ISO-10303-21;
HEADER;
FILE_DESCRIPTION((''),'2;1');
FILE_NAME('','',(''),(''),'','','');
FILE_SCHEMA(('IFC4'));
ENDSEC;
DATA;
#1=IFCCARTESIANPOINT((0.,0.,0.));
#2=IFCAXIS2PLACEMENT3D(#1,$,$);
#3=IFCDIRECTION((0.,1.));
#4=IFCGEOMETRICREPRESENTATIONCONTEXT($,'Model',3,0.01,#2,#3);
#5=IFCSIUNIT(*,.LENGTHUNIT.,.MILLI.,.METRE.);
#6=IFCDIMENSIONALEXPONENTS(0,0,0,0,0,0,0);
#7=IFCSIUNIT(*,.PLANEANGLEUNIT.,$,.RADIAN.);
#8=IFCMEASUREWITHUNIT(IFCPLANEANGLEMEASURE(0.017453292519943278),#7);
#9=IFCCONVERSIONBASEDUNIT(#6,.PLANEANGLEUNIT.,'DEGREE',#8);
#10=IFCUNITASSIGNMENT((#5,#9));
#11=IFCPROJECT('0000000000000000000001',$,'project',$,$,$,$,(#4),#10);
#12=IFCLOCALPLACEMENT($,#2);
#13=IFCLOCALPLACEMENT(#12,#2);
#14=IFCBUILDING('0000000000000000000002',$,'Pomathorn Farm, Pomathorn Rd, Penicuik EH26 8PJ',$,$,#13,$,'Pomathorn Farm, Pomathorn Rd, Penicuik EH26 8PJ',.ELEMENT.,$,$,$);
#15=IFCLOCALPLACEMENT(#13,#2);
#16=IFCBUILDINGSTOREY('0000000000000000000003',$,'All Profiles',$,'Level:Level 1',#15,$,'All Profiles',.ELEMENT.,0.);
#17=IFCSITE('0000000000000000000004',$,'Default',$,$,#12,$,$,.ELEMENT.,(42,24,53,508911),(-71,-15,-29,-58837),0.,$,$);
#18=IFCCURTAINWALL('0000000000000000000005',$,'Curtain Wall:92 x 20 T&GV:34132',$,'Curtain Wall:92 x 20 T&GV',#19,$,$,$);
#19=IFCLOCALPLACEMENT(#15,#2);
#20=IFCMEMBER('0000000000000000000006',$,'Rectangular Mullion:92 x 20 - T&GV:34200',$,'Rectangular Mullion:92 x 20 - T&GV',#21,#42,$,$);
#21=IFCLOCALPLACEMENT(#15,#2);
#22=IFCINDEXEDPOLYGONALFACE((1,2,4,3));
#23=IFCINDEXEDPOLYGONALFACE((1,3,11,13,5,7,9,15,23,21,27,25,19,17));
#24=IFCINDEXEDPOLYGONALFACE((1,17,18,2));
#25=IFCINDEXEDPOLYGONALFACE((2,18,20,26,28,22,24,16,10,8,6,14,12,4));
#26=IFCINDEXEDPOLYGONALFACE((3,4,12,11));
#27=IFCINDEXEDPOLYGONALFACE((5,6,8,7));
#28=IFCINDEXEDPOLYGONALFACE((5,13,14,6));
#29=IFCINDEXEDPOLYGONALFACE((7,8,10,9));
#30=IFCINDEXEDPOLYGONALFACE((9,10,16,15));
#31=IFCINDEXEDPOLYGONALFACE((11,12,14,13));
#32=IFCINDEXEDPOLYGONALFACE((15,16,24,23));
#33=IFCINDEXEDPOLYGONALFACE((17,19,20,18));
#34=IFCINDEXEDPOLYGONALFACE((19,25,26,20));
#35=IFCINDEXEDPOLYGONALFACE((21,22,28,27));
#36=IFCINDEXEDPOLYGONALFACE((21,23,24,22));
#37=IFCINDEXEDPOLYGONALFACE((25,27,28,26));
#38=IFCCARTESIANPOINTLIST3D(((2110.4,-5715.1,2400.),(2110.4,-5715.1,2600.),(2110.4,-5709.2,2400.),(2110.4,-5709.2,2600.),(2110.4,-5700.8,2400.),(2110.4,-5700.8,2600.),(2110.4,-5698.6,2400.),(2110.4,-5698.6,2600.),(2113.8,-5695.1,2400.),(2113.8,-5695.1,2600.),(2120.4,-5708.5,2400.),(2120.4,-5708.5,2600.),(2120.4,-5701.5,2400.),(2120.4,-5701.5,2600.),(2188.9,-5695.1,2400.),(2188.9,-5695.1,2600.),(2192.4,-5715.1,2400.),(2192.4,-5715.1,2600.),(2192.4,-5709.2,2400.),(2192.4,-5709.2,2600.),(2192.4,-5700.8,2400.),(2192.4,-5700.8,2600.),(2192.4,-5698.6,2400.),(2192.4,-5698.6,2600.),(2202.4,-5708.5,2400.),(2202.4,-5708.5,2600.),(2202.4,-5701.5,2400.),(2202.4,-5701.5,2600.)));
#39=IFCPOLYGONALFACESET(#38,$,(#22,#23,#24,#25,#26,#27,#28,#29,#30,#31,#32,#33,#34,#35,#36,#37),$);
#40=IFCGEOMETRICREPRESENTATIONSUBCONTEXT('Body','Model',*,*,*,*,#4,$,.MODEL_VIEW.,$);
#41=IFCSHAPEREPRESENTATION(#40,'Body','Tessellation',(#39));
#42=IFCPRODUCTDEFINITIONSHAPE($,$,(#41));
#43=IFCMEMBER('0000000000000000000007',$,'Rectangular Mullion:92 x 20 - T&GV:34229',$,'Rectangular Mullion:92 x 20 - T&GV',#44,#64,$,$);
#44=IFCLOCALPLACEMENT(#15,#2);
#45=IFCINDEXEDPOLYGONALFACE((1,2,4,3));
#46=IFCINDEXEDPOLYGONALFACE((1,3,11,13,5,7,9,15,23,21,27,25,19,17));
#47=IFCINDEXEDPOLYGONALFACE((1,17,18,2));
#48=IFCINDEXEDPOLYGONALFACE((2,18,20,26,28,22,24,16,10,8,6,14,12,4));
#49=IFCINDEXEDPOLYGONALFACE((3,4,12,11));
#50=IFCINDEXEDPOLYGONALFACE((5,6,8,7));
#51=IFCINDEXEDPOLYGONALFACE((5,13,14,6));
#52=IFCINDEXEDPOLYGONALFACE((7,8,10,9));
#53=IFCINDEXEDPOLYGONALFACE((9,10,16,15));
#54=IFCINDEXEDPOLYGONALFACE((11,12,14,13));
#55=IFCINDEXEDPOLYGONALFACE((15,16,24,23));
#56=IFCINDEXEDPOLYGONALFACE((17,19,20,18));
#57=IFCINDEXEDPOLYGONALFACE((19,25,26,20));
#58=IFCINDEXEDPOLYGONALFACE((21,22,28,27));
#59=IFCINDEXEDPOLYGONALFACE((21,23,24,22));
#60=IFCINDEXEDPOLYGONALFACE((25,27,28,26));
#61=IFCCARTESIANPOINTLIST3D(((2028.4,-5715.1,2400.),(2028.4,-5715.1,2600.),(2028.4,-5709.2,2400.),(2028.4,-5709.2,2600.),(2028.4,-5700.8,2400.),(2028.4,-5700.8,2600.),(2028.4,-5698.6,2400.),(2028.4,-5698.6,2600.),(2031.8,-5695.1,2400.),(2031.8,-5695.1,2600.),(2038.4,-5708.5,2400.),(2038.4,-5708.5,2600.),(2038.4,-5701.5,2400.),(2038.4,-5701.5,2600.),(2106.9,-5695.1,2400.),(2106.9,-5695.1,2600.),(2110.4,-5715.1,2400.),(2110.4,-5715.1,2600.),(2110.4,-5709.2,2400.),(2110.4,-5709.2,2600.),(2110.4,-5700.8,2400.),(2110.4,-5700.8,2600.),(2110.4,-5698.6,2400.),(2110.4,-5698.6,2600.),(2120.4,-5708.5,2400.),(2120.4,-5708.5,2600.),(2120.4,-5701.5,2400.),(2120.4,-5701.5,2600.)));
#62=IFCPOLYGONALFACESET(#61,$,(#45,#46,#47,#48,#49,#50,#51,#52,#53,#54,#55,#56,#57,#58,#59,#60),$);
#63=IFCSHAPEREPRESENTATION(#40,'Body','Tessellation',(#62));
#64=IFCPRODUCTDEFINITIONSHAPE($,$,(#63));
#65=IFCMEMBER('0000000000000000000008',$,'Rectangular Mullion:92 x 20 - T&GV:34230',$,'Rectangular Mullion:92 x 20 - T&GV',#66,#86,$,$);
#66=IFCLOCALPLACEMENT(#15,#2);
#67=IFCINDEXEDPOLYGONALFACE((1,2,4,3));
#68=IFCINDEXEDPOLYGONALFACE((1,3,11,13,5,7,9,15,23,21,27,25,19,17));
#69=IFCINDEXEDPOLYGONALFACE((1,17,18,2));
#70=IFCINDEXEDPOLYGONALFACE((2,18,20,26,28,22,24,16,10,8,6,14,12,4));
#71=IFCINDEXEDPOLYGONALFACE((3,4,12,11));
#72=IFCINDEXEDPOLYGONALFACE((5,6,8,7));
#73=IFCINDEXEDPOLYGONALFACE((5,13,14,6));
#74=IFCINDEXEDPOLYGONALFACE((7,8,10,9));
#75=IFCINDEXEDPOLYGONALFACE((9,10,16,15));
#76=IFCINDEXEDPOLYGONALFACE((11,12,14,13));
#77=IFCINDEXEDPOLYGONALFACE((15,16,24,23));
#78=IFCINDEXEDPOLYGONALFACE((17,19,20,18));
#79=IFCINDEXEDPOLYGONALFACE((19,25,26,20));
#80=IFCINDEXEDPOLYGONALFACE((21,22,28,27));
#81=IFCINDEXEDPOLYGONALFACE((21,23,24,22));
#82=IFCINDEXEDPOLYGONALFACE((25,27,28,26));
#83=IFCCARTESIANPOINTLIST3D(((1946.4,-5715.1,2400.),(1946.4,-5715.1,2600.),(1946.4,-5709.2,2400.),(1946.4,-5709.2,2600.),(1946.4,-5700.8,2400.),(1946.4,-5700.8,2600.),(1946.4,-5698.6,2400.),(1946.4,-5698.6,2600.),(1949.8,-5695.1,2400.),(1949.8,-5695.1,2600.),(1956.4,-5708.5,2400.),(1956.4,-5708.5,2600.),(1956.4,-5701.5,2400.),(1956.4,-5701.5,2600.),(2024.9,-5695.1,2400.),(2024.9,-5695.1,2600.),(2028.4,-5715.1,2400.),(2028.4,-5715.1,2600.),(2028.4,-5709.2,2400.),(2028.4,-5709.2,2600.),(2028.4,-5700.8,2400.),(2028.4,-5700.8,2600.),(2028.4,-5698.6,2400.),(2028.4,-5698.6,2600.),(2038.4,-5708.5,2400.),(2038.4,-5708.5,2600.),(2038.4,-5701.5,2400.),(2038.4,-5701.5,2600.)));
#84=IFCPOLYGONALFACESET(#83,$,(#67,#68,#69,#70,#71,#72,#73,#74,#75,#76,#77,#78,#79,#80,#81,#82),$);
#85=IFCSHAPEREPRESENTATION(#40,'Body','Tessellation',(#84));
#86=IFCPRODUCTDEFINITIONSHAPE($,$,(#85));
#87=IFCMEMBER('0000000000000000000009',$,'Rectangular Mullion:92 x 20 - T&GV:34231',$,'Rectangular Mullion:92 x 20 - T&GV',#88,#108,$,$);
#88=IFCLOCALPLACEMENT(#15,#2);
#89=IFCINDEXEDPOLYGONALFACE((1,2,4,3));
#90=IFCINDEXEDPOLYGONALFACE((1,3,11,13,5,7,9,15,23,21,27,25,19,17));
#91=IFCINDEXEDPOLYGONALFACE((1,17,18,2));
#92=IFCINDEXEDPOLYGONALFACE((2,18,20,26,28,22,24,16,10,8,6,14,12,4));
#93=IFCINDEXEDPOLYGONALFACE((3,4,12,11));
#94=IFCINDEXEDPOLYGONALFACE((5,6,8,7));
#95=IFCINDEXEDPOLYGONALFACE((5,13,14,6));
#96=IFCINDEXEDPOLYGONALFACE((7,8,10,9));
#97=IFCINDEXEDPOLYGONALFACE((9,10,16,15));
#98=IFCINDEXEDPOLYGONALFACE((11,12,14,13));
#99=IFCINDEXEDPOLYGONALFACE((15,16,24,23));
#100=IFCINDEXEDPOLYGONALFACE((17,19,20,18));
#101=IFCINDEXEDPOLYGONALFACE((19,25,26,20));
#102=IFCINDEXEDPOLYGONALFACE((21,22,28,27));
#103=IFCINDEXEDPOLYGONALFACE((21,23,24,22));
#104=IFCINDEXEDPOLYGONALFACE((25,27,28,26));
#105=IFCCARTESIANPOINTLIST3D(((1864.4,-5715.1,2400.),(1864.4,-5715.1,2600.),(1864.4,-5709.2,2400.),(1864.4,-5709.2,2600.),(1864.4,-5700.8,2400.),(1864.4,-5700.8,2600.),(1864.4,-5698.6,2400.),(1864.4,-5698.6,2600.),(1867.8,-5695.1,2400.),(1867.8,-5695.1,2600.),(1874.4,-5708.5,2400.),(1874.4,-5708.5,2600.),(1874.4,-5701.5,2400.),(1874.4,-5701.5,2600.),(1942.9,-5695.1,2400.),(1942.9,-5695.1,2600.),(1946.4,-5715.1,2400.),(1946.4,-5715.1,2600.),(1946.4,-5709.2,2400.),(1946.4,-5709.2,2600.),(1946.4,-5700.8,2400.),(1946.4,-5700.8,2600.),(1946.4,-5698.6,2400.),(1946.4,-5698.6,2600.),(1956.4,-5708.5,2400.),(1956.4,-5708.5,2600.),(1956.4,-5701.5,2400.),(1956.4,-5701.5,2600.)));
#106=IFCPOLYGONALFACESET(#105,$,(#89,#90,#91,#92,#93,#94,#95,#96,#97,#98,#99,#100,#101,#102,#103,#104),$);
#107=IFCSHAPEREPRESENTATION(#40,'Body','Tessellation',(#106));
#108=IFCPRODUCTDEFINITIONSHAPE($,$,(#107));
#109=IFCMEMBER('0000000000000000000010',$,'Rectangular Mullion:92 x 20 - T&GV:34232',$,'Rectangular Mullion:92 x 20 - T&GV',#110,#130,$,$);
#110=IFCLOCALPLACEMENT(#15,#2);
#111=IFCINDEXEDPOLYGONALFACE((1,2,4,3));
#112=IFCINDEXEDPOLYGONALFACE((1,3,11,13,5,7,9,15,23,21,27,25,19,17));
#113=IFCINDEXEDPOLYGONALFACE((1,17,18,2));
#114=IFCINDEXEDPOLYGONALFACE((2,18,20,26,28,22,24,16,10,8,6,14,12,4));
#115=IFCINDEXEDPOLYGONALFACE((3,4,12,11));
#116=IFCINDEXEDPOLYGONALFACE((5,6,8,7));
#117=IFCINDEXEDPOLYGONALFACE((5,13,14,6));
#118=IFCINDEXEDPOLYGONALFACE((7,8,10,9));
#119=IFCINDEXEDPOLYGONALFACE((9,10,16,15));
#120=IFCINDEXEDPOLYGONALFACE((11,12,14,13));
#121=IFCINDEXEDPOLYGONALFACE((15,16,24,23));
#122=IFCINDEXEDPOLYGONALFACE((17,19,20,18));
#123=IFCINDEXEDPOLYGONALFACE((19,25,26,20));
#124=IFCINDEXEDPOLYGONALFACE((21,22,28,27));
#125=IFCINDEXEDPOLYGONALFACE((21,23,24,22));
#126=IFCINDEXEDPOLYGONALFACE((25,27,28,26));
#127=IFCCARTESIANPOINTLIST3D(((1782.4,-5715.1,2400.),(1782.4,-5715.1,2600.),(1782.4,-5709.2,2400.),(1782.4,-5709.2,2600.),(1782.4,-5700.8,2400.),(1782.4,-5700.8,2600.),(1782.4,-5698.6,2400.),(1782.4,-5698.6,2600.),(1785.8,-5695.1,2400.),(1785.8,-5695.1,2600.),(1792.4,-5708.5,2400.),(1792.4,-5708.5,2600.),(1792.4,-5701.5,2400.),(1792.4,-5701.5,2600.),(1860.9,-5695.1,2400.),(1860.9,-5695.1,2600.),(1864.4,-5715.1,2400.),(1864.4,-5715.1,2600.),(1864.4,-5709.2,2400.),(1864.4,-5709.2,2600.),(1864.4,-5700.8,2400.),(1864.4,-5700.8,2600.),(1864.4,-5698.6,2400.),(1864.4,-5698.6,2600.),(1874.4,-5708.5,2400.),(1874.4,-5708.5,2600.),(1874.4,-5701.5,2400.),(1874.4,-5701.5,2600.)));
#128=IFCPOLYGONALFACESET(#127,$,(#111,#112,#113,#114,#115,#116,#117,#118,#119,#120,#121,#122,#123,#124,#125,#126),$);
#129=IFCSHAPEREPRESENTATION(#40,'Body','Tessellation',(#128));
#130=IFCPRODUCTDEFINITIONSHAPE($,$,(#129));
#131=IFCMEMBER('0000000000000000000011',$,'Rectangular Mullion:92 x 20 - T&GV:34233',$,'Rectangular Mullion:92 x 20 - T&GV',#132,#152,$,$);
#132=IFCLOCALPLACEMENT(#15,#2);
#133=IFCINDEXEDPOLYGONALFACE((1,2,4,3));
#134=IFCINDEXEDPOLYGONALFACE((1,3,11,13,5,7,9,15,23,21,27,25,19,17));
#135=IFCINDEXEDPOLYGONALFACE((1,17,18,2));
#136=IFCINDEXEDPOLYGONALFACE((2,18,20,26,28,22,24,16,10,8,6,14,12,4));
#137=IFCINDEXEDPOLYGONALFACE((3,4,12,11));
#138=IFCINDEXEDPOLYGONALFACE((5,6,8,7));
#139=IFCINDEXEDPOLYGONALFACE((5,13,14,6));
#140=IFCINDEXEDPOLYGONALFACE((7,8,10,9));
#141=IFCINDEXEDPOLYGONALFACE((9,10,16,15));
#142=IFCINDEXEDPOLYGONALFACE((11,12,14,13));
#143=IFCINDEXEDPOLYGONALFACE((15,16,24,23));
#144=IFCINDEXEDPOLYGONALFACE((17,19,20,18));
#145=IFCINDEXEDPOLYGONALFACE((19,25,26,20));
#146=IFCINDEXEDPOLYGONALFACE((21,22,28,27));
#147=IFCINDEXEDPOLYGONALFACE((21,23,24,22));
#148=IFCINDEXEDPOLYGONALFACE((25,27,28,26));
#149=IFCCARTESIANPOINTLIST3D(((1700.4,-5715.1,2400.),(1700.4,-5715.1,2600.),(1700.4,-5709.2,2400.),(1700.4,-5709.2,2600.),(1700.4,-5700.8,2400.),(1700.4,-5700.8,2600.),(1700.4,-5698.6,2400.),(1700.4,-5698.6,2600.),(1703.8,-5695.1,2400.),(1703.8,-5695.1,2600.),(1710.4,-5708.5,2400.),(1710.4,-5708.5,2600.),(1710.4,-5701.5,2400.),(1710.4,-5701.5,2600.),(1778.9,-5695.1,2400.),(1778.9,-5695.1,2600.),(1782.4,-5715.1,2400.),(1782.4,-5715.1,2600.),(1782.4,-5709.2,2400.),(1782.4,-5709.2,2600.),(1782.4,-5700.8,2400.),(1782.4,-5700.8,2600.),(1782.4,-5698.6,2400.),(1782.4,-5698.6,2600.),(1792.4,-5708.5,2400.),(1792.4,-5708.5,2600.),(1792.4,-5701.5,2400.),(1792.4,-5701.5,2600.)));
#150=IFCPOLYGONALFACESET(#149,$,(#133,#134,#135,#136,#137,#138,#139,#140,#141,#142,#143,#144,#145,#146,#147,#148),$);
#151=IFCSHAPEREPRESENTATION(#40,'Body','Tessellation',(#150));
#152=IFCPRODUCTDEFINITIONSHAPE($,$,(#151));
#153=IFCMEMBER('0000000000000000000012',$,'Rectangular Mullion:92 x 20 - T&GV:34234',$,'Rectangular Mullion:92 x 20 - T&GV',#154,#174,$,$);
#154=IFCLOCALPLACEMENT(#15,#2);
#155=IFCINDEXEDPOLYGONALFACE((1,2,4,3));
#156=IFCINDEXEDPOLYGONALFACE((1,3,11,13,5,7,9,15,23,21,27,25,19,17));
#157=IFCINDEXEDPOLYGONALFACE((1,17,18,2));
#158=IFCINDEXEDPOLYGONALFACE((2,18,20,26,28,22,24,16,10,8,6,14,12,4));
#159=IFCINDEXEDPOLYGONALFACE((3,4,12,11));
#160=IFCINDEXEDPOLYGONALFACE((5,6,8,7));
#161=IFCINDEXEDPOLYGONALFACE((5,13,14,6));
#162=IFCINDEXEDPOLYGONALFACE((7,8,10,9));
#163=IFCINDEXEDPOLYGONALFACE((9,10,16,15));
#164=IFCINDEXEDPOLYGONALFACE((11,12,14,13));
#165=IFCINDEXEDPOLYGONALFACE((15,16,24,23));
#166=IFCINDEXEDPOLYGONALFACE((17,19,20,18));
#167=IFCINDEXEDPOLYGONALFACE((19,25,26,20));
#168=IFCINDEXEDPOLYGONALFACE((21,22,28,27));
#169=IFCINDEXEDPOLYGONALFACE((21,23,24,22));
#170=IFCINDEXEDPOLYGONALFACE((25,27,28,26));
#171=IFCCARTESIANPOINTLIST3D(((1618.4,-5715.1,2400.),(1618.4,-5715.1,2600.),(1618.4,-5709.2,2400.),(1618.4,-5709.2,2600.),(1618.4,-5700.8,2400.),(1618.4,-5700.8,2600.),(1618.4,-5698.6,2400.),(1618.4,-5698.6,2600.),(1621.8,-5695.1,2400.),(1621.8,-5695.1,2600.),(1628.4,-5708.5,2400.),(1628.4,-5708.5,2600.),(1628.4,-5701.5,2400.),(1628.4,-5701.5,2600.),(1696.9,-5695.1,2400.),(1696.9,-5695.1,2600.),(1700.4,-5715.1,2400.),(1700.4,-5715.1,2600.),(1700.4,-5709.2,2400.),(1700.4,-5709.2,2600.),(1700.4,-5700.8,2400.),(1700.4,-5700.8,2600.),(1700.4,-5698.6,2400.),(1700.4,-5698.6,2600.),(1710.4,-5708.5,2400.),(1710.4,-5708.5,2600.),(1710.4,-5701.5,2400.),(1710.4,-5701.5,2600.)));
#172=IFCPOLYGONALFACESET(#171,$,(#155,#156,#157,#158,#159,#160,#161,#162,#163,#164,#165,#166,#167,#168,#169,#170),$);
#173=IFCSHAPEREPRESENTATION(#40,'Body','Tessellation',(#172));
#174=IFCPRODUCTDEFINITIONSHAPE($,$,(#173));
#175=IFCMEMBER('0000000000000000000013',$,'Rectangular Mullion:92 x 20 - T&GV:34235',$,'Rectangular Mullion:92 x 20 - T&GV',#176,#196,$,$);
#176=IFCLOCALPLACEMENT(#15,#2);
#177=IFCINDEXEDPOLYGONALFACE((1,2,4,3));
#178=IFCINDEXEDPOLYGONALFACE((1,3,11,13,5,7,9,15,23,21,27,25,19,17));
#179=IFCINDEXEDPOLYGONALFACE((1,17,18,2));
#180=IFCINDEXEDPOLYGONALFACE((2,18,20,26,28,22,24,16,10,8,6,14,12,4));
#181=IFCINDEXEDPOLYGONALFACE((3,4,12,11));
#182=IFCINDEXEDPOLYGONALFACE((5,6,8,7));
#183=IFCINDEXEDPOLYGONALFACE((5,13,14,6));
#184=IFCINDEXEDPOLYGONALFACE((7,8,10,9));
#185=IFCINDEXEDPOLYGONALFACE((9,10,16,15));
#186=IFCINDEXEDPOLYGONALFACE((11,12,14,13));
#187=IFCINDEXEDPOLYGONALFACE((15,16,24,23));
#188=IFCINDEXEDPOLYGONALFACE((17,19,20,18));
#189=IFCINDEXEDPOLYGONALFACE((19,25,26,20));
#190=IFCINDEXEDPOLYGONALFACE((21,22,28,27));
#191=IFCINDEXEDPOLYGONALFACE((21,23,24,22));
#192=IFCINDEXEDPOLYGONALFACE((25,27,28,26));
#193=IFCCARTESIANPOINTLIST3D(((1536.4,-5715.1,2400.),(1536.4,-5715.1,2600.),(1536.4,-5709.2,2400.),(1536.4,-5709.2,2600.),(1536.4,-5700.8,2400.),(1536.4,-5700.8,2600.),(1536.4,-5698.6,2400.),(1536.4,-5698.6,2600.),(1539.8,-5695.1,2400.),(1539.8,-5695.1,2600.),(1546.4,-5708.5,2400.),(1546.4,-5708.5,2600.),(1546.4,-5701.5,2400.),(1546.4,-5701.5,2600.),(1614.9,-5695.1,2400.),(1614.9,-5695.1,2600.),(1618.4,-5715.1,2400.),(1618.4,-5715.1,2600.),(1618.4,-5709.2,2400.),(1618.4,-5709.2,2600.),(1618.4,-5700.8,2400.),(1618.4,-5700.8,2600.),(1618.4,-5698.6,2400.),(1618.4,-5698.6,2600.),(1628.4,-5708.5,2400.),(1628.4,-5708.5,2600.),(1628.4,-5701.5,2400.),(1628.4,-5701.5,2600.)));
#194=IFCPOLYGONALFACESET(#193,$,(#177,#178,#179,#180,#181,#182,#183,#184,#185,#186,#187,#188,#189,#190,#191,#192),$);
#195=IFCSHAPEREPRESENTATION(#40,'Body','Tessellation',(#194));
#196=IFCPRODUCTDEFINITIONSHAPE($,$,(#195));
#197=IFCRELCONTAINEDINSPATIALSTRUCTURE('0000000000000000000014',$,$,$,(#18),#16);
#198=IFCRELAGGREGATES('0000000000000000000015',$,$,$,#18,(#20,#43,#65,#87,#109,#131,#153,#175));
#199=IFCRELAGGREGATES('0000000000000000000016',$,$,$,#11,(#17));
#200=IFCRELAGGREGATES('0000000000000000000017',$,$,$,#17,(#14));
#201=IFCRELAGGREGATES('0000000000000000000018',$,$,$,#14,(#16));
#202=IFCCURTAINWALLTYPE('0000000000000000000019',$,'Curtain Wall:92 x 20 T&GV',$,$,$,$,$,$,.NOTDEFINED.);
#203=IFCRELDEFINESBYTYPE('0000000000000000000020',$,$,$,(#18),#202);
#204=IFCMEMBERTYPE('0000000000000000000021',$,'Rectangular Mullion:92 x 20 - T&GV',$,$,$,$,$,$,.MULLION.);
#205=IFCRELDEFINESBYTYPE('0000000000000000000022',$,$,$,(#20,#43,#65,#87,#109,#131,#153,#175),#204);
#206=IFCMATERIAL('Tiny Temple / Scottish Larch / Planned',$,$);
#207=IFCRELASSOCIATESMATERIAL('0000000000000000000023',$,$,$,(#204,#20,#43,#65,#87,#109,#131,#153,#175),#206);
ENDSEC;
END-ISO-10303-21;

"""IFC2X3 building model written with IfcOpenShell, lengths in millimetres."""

from ifc_helpers import new_model, entity, si_unit, converted_unit, direction, frame, origin, place, context, subcontext, project, spatial, polyline, outline, extrude, source, transform, mapped, material, type_object, type_shapes, element, aggregate, save


model = new_model("IFC2X3")

# Units and contexts
model_context = context("Model", 3, precision=0.01, world=origin(), true_north=direction((0.0, 1.0)))
body_context = subcontext(model_context, "Body", "Model", "MODEL_VIEW")
ifc_project = project(units=[si_unit("LENGTHUNIT", "METRE", prefix="MILLI"), converted_unit("PLANEANGLEUNIT", "DEGREE", entity("IfcPlaneAngleMeasure", 0.017453292519943278), si_unit("PLANEANGLEUNIT", "RADIAN"), dimensions=[0, 0, 0, 0, 0, 0, 0])], contexts=[model_context])

# Site, building, storey
site_placement = place(None, origin())
site = spatial("IfcSite", under=ifc_project, at=site_placement, Name="Default", CompositionType="ELEMENT", RefLatitude=(42, 24, 53, 508911), RefLongitude=(-71, -15, -29, -58837), RefElevation=0.0)
building_placement = place(site_placement, origin())
building = spatial("IfcBuilding", under=site, at=building_placement, Name="Pomathorn Farm, Pomathorn Rd, Penicuik EH26 8PJ", LongName="Pomathorn Farm, Pomathorn Rd, Penicuik EH26 8PJ", CompositionType="ELEMENT")
storey_placement = place(building_placement, origin())
storey = spatial("IfcBuildingStorey", under=building, at=storey_placement, Name="All Profiles", ObjectType="Level:Level 1", LongName="All Profiles", CompositionType="ELEMENT", Elevation=0.0)

# Shared definitions
ifc_material = material(Name="Tiny Temple / Scottish Larch / Planned")

# Curtain wall, members
curtain_wall_type_1 = type_object("IfcCurtainWallType", Name="Curtain Wall:92 x 20 T&GV", PredefinedType="NOTDEFINED")
curtain_wall_1_placement = place(storey_placement, origin())
curtain_wall_1 = element("IfcCurtainWall", 1, at=curtain_wall_1_placement, inside=storey, type_object=curtain_wall_type_1, Name="Curtain Wall:92 x 20 T&GV:34132", ObjectType="Curtain Wall:92 x 20 T&GV")
member_type_1 = type_object("IfcMemberType", Name="Rectangular Mullion:92 x 20 - T&GV", PredefinedType="MULLION", material=ifc_material)
shared_shape_1 = source(origin(), body_context, "Body", "SweptSolid", [
    extrude(outline(polyline([(-38.1, -11.0), (43.9, -11.0), (43.9, -5.1), (33.9, -4.4), (33.9, 2.6), (43.9, 3.3), (43.9, 5.5), (40.4, 9.0), (-34.7, 9.0), (-38.1, 5.5), (-38.1, 3.3), (-48.1, 2.6), (-48.1, -4.4), (-38.1, -5.1), (-38.1, -11.0)])), frame((-48.1, -11.0, -200.0), z_axis=(0.0, 0.0, 1.0), x_axis=(-1.0, 0.0, 0.0)), (0.0, 0.0, 1.0), 200.0),
])
type_shapes(member_type_1, [shared_shape_1])
member_1_placement = place(curtain_wall_1_placement, frame((2202.4, -5715.1, 2400.0), z_axis=(0.0, 0.0, -1.0), x_axis=(1.0, 0.0, 0.0)))
member_1 = element("IfcMember", 2, at=member_1_placement, type_object=member_type_1, material=ifc_material, Name="Rectangular Mullion:92 x 20 - T&GV:34200", ObjectType="Rectangular Mullion:92 x 20 - T&GV", context=body_context, shape_type="MappedRepresentation", body=[
    mapped(shared_shape_1, transform((0.0, 0.0, 0.0), scale=1.0)),
])
member_2_placement = place(curtain_wall_1_placement, frame((2120.4, -5715.1, 2400.0), z_axis=(0.0, 0.0, -1.0), x_axis=(1.0, 0.0, 0.0)))
member_2 = element("IfcMember", 3, at=member_2_placement, type_object=member_type_1, material=ifc_material, Name="Rectangular Mullion:92 x 20 - T&GV:34229", ObjectType="Rectangular Mullion:92 x 20 - T&GV", context=body_context, shape_type="MappedRepresentation", body=[
    mapped(shared_shape_1, transform((0.0, 0.0, 0.0), scale=1.0)),
])
member_3_placement = place(curtain_wall_1_placement, frame((2038.4, -5715.1, 2400.0), z_axis=(0.0, 0.0, -1.0), x_axis=(1.0, 0.0, 0.0)))
member_3 = element("IfcMember", 4, at=member_3_placement, type_object=member_type_1, material=ifc_material, Name="Rectangular Mullion:92 x 20 - T&GV:34230", ObjectType="Rectangular Mullion:92 x 20 - T&GV", context=body_context, shape_type="MappedRepresentation", body=[
    mapped(shared_shape_1, transform((0.0, 0.0, 0.0), scale=1.0)),
])
member_4_placement = place(curtain_wall_1_placement, frame((1956.4, -5715.1, 2400.0), z_axis=(0.0, 0.0, -1.0), x_axis=(1.0, 0.0, 0.0)))
member_4 = element("IfcMember", 5, at=member_4_placement, type_object=member_type_1, material=ifc_material, Name="Rectangular Mullion:92 x 20 - T&GV:34231", ObjectType="Rectangular Mullion:92 x 20 - T&GV", context=body_context, shape_type="MappedRepresentation", body=[
    mapped(shared_shape_1, transform((0.0, 0.0, 0.0), scale=1.0)),
])
member_5_placement = place(curtain_wall_1_placement, frame((1874.4, -5715.1, 2400.0), z_axis=(0.0, 0.0, -1.0), x_axis=(1.0, 0.0, 0.0)))
member_5 = element("IfcMember", 6, at=member_5_placement, type_object=member_type_1, material=ifc_material, Name="Rectangular Mullion:92 x 20 - T&GV:34232", ObjectType="Rectangular Mullion:92 x 20 - T&GV", context=body_context, shape_type="MappedRepresentation", body=[
    mapped(shared_shape_1, transform((0.0, 0.0, 0.0), scale=1.0)),
])
member_6_placement = place(curtain_wall_1_placement, frame((1792.4, -5715.1, 2400.0), z_axis=(0.0, 0.0, -1.0), x_axis=(1.0, 0.0, 0.0)))
member_6 = element("IfcMember", 7, at=member_6_placement, type_object=member_type_1, material=ifc_material, Name="Rectangular Mullion:92 x 20 - T&GV:34233", ObjectType="Rectangular Mullion:92 x 20 - T&GV", context=body_context, shape_type="MappedRepresentation", body=[
    mapped(shared_shape_1, transform((0.0, 0.0, 0.0), scale=1.0)),
])
member_7_placement = place(curtain_wall_1_placement, frame((1710.4, -5715.1, 2400.0), z_axis=(0.0, 0.0, -1.0), x_axis=(1.0, 0.0, 0.0)))
member_7 = element("IfcMember", 8, at=member_7_placement, type_object=member_type_1, material=ifc_material, Name="Rectangular Mullion:92 x 20 - T&GV:34234", ObjectType="Rectangular Mullion:92 x 20 - T&GV", context=body_context, shape_type="MappedRepresentation", body=[
    mapped(shared_shape_1, transform((0.0, 0.0, 0.0), scale=1.0)),
])
member_8_placement = place(curtain_wall_1_placement, frame((1628.4, -5715.1, 2400.0), z_axis=(0.0, 0.0, -1.0), x_axis=(1.0, 0.0, 0.0)))
member_8 = element("IfcMember", 9, at=member_8_placement, type_object=member_type_1, material=ifc_material, Name="Rectangular Mullion:92 x 20 - T&GV:34235", ObjectType="Rectangular Mullion:92 x 20 - T&GV", context=body_context, shape_type="MappedRepresentation", body=[
    mapped(shared_shape_1, transform((0.0, 0.0, 0.0), scale=1.0)),
])
aggregate(curtain_wall_1, [member_1, member_2, member_3, member_4, member_5, member_6, member_7, member_8])

save(model, "model.ifc")
